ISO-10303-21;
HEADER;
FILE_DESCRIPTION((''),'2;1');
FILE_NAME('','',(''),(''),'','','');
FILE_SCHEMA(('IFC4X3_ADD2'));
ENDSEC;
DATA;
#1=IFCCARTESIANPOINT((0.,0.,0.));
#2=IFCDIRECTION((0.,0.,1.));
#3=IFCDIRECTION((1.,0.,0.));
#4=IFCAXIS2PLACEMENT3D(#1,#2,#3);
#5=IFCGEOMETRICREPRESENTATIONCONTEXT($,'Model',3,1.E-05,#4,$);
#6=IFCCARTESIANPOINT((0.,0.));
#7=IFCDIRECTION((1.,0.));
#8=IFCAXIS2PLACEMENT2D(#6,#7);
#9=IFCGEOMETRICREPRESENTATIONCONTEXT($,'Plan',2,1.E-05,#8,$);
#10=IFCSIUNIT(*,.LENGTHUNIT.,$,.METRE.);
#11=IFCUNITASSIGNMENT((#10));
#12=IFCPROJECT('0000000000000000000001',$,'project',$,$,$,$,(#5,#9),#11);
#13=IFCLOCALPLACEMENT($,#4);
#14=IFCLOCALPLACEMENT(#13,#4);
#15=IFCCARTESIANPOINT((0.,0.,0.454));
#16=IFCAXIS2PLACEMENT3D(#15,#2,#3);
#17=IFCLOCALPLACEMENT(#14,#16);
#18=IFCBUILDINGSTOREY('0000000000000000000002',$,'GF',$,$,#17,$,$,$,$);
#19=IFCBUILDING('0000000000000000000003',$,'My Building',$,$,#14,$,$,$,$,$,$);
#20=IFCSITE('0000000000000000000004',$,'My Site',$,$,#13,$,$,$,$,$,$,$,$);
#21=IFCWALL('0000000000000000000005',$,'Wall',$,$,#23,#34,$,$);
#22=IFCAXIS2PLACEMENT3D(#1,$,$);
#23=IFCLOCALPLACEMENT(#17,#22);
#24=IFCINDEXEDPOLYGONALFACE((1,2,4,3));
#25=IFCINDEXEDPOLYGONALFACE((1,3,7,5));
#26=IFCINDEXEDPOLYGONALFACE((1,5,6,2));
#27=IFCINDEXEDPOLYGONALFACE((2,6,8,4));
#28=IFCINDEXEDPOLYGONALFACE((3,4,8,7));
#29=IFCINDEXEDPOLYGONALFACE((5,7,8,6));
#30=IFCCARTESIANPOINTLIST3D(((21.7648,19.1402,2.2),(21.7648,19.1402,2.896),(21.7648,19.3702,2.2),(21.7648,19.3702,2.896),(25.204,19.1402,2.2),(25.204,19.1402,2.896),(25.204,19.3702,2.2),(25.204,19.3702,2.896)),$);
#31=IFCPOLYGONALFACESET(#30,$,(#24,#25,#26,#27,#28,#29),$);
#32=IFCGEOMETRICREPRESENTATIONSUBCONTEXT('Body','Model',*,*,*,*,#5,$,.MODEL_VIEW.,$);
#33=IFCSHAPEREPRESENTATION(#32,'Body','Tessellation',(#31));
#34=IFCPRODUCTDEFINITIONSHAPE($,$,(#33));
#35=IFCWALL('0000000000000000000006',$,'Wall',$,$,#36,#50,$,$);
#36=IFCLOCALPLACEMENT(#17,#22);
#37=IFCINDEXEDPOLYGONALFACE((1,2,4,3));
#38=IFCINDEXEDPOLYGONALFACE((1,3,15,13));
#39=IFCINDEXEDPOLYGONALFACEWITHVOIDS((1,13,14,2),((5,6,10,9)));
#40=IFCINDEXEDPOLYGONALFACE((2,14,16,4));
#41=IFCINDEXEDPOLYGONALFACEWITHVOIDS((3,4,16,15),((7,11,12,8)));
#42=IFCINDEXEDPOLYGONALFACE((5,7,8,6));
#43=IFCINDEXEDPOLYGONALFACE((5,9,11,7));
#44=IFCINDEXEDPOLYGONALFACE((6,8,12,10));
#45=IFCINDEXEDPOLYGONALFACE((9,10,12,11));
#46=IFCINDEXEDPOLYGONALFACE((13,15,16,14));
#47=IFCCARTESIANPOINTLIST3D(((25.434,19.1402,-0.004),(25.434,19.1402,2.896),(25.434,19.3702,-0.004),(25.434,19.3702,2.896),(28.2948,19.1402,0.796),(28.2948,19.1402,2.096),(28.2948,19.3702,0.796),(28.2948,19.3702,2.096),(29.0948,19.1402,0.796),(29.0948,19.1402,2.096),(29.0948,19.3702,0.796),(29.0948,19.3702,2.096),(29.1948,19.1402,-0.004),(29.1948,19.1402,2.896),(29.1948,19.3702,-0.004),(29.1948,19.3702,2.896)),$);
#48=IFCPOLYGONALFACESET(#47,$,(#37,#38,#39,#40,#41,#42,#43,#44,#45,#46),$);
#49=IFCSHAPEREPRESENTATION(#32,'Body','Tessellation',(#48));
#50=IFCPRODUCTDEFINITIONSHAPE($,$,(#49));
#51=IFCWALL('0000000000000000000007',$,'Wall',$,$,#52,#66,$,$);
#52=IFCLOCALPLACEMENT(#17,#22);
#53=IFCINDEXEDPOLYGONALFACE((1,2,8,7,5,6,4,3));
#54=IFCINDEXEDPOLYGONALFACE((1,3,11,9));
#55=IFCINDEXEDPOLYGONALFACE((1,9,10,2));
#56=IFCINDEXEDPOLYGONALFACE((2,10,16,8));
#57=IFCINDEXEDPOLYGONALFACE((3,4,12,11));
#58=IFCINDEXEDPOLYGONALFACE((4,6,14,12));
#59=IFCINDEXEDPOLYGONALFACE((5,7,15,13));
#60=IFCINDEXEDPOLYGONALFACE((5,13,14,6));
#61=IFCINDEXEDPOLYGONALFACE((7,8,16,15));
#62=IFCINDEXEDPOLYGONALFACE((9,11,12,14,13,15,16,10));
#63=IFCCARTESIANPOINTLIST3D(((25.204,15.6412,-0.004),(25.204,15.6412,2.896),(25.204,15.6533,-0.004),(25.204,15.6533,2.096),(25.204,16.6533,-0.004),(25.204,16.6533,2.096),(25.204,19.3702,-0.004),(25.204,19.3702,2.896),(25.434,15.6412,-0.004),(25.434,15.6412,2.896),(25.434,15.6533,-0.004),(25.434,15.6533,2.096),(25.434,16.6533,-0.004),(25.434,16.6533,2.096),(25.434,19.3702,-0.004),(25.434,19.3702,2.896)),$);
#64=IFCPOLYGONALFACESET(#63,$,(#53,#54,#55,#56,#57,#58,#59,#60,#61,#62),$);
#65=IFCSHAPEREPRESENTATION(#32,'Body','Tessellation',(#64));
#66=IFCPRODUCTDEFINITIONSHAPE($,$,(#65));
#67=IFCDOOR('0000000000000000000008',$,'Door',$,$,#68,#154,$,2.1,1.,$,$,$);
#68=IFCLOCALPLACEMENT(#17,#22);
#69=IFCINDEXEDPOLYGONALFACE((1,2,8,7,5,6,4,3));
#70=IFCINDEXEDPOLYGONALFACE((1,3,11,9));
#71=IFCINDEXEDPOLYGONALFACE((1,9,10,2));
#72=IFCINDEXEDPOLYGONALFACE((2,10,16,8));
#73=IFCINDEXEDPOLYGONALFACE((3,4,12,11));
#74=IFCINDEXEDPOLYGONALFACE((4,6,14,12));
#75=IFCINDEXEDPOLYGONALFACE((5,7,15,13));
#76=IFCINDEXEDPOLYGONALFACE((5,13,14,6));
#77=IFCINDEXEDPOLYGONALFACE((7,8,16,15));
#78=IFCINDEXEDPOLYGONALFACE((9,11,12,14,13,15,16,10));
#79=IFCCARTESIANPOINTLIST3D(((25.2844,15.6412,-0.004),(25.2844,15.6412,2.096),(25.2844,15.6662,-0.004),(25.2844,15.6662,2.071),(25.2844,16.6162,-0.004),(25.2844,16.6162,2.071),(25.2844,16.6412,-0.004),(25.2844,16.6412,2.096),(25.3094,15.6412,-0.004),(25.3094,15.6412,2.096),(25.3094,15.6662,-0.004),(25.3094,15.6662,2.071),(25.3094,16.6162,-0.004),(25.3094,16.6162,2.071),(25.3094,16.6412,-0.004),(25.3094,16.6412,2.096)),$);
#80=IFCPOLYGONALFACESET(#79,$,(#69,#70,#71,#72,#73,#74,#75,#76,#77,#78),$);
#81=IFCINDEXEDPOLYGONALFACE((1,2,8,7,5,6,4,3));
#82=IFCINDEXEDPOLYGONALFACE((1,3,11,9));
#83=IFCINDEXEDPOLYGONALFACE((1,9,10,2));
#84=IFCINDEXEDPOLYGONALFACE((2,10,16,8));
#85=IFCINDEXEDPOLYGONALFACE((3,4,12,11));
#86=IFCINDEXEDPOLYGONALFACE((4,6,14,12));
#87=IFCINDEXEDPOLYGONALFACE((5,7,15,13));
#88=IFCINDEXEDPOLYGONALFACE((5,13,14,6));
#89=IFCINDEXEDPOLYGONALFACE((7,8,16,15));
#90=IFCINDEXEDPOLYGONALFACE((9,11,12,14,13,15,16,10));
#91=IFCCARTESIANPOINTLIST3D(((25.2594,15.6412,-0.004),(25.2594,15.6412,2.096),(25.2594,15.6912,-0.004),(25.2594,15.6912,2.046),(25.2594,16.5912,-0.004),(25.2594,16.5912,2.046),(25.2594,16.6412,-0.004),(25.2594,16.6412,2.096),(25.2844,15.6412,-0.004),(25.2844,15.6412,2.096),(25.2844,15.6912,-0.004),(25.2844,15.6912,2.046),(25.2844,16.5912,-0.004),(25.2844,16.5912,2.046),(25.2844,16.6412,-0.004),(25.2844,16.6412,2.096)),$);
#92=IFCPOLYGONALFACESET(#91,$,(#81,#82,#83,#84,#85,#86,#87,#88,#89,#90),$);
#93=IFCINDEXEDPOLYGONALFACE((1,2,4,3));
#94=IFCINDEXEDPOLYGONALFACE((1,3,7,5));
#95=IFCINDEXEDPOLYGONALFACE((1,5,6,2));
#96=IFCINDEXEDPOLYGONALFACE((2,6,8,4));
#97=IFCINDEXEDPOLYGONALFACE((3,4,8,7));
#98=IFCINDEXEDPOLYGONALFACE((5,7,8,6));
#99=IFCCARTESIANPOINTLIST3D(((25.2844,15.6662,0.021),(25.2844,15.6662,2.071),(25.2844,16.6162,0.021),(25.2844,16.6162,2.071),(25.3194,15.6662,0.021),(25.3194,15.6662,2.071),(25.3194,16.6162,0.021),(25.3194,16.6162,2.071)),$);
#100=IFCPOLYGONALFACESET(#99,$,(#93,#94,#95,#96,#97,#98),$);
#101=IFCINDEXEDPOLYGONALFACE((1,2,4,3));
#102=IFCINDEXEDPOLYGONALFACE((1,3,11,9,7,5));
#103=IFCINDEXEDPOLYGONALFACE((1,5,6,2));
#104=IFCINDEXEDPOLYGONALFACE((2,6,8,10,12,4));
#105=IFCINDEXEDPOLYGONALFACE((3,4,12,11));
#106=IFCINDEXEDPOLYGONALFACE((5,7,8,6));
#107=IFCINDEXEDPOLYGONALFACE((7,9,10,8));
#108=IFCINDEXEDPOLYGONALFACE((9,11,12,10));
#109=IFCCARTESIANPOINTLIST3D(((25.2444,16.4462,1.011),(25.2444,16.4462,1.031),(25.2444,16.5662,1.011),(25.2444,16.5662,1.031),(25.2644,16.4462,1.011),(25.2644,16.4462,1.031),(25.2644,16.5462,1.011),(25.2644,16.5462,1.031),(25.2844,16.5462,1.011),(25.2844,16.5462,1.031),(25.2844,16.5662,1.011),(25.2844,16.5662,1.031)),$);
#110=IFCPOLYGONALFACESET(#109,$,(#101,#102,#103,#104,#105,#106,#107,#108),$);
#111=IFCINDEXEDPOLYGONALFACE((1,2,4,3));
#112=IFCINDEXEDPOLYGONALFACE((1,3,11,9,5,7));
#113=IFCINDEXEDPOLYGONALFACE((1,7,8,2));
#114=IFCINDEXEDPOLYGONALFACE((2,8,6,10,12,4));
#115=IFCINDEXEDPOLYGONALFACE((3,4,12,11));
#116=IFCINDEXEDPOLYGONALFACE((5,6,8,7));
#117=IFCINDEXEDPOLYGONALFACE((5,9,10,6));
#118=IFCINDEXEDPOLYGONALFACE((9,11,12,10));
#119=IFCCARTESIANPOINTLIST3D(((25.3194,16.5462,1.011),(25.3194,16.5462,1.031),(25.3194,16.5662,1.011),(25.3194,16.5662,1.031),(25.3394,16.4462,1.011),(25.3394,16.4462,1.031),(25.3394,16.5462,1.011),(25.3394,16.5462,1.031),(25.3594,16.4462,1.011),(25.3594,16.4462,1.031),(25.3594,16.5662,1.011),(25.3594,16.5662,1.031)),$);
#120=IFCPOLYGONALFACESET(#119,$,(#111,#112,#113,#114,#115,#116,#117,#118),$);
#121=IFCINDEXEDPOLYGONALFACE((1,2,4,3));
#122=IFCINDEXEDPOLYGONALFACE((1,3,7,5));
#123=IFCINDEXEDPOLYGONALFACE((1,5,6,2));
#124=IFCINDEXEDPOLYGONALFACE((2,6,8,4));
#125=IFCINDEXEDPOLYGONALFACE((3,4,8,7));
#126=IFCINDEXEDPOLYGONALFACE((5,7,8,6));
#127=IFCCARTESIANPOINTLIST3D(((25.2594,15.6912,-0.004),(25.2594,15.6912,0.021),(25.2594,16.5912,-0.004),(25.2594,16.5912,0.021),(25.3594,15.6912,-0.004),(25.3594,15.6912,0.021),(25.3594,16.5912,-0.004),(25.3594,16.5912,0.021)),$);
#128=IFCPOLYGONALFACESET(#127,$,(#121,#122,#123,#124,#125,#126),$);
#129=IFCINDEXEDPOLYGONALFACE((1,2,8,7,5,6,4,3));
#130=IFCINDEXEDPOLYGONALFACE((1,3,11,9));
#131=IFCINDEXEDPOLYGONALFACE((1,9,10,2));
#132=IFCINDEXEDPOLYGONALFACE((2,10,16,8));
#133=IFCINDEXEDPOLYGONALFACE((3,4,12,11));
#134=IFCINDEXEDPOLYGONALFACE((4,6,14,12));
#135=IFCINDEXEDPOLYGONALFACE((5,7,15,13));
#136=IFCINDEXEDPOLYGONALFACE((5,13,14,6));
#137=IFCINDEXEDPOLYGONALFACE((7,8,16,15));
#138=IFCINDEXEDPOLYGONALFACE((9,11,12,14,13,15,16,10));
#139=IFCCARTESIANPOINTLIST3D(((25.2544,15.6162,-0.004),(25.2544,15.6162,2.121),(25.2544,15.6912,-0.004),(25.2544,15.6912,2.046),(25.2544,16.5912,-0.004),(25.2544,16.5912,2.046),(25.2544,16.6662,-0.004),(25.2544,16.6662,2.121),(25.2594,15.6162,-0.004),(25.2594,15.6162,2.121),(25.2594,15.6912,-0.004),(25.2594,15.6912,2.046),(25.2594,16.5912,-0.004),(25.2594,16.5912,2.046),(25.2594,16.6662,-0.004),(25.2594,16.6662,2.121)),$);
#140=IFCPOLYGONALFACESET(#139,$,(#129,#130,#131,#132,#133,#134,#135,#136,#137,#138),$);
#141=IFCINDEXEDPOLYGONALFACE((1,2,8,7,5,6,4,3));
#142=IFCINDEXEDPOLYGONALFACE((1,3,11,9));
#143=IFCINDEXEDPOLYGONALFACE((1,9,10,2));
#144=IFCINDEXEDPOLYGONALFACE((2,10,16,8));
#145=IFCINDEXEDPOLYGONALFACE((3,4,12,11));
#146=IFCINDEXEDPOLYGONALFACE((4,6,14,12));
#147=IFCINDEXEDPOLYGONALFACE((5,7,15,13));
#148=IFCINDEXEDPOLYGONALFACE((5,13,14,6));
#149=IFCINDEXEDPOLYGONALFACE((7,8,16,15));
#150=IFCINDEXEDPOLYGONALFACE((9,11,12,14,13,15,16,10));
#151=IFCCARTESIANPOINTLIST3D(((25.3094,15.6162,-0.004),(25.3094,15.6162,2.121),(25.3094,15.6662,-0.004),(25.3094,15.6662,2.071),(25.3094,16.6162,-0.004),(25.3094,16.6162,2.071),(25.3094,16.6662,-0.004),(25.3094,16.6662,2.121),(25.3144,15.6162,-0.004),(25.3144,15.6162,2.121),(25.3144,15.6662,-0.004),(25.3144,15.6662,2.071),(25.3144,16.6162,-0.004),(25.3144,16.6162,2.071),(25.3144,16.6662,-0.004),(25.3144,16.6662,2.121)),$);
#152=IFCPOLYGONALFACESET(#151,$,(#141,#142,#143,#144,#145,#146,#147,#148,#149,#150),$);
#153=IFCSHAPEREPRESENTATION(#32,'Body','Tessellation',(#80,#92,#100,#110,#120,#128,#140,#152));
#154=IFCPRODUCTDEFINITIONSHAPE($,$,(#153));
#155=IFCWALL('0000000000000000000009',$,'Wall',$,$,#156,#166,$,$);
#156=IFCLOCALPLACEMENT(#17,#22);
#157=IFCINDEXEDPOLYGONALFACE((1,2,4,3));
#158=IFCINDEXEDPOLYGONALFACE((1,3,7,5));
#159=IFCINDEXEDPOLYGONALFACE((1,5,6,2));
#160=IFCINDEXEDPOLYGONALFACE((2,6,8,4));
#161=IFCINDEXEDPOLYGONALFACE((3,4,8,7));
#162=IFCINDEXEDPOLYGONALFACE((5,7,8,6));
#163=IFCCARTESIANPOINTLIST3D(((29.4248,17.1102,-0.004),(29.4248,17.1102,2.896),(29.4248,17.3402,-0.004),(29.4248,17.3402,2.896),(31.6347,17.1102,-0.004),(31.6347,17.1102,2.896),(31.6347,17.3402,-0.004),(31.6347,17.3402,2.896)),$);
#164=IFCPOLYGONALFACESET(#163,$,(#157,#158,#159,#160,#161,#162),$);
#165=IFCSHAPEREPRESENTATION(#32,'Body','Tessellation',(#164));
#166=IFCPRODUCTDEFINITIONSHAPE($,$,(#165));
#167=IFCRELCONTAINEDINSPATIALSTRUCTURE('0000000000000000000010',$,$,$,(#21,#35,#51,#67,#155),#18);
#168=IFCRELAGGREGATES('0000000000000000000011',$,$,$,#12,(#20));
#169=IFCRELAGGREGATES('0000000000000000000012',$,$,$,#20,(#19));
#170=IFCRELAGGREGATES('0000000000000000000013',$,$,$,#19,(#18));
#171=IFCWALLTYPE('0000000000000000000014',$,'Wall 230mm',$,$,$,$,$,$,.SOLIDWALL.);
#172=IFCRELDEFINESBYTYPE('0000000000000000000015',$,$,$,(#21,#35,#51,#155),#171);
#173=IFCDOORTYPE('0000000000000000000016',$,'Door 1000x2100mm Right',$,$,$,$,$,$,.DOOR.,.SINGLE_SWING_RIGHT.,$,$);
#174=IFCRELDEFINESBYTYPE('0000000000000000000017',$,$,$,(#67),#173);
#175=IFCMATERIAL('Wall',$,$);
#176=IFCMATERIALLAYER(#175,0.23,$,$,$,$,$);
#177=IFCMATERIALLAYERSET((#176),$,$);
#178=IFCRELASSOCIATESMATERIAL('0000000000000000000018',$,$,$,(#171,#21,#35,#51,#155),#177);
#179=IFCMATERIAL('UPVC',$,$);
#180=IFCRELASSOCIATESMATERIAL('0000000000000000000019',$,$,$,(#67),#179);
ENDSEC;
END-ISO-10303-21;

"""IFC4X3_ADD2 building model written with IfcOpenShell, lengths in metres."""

from ifc_helpers import new_model, entity, si_unit, frame, origin_with_axes, origin_2d_with_axis, place, context, subcontext, project, spatial, line, indexed_curve, outline, extrude, clip, halfspace, shape, source, transform, mapped, material, layer, layer_set, layer_usage, type_object, type_shapes, element, fill, save


model = new_model("IFC4X3_ADD2")

# Units and contexts
model_context = context("Model", 3, precision=1e-05, world=origin_with_axes())
plan_context = context("Plan", 2, precision=1e-05, world=origin_2d_with_axis())
body_context_1 = subcontext(model_context, "Body", "Model", "MODEL_VIEW")
body_context_2 = subcontext(plan_context, "Body", "Plan", "PLAN_VIEW")
ifc_project = project(units=[si_unit("LENGTHUNIT", "METRE")], contexts=[model_context, plan_context])

# Site, building, storey
site_placement = place(None, origin_with_axes())
site = spatial("IfcSite", under=ifc_project, at=site_placement, Name="My Site")
building_placement = place(site_placement, origin_with_axes())
building = spatial("IfcBuilding", under=site, at=building_placement, Name="My Building")
storey_placement = place(building_placement, frame((0.0, 0.0, 0.454), z_axis=(0.0, 0.0, 1.0), x_axis=(1.0, 0.0, 0.0)))
storey = spatial("IfcBuildingStorey", under=building, at=storey_placement, Name="GF")

# Shared definitions
ifc_material_1 = material(Name="Wall")
ifc_layer = layer(ifc_material_1, 0.23)
ifc_layer_set = layer_set([ifc_layer])
wall_type = type_object("IfcWallType", Name="Wall 230mm", PredefinedType="SOLIDWALL", material=ifc_layer_set)
shared_shape_1 = source(origin_with_axes(), body_context_1, "Body", "SweptSolid", [
    extrude(outline(indexed_curve([(0.0, 0.0), (0.8, 0.0), (0.8, 1.3), (0.0, 1.3)], segments=[line(1, 2, 3, 4, 1)])), frame((-0.4, -0.6, 0.0), z_axis=(0.0, -1.0, 0.0), x_axis=(1.0, 0.0, 0.0)), (0.0, 0.0, -1.0), 1.2),
])

# Wall
ifc_layer_usage_1 = layer_usage(ifc_layer_set, "AXIS2", "POSITIVE", 0.0)
wall_1_placement = place(storey_placement, frame((25.204, 19.3702, 2.2), z_axis=(0.0, 0.0, 1.0), x_axis=(-1.0, 0.0, 0.0)))
element("IfcWall", 1, at=wall_1_placement, inside=storey, type_object=wall_type, material=ifc_layer_usage_1, Name="Wall", context=body_context_1, shape_type="Clipping", body=[
    clip(clip(extrude(outline(indexed_curve([(0.0, 0.0), (0.0, 0.23), (3.4392, 0.23), (3.4392, 0.0), (0.0, 0.0)], self_intersect=False)), origin_with_axes(), (0.0, 0.0, 1.0), 6.25), halfspace(frame((0.0, 0.0, 3.596), z_axis=(0.0, 0.0, 1.0), x_axis=(-1.0, 0.0, 0.0)), False)), halfspace(frame((0.0, 0.0, 0.696), z_axis=(0.0, 0.0, 1.0), x_axis=(-1.0, 0.0, 0.0)), False)),
])

# Wall, opening
ifc_layer_usage_2 = layer_usage(ifc_layer_set, "AXIS2", "POSITIVE", 0.0)
wall_2_placement = place(storey_placement, frame((29.1948, 19.3702, -0.004), z_axis=(0.0, 0.0, 1.0), x_axis=(-1.0, 0.0, 0.0)))
wall_2 = element("IfcWall", 2, at=wall_2_placement, inside=storey, type_object=wall_type, material=ifc_layer_usage_2, Name="Wall", context=body_context_1, shape_type="SweptSolid", body=[
    extrude(outline(indexed_curve([(0.0, 0.0), (0.0, 0.23), (3.7608, 0.23), (3.7608, 0.0), (0.0, 0.0)], self_intersect=False)), origin_with_axes(), (0.0, 0.0, 1.0), 2.9),
])
opening_1_placement = place(wall_2_placement, frame((0.5, 0.16, 0.8), z_axis=(0.0, 0.0, 1.0), x_axis=(1.0, 0.0, 0.0)))
element("IfcOpeningElement", 3, at=opening_1_placement, cuts=wall_2, PredefinedType="OPENING", context=body_context_1, shape_type="MappedRepresentation", body=[
    mapped(shared_shape_1, transform((0.0, 0.0, 0.0), x_axis=(1.0, 0.0, 0.0), y_axis=(0.0, 1.0, 0.0), z_axis=(0.0, 0.0, 1.0), scale=1.0)),
])

# Wall, opening, door
ifc_layer_usage_3 = layer_usage(ifc_layer_set, "AXIS2", "POSITIVE", 0.0)
wall_3_placement = place(storey_placement, frame((25.434, 15.6412, -0.004), z_axis=(0.0, 0.0, 1.0), x_axis=(0.000001, 1.0, 0.0)))
wall_3 = element("IfcWall", 4, at=wall_3_placement, inside=storey, type_object=wall_type, material=ifc_layer_usage_3, Name="Wall", context=body_context_1, shape_type="SweptSolid", body=[
    extrude(outline(indexed_curve([(0.0, 0.0), (0.0, 0.23), (3.729, 0.23), (3.729, 0.0), (0.0, 0.0)], self_intersect=False)), origin_with_axes(), (0.0, 0.0, 1.0), 2.9),
])
shared_shape_2 = source(origin_with_axes(), body_context_1, "Body", "SweptSolid", [
    extrude(outline(indexed_curve([(0.0, 0.0), (1.0, 0.0), (1.0, 2.1), (0.0, 2.1)], segments=[line(1, 2, 3, 4, 1)])), frame((0.0, -0.6, 0.0), z_axis=(0.0, -1.0, 0.0), x_axis=(1.0, 0.0, 0.0)), (0.0, 0.0, -1.0), 1.2),
])
opening_2_placement = place(wall_3_placement, frame((0.012, 0.0, 0.0), z_axis=(0.0, 0.0, 1.0), x_axis=(1.0, 0.0, 0.0)))
opening_2 = element("IfcOpeningElement", 5, at=opening_2_placement, cuts=wall_3, PredefinedType="OPENING", context=body_context_1, shape_type="MappedRepresentation", body=[
    mapped(shared_shape_2, transform((0.0, 0.0, 0.0), x_axis=(1.0, 0.0, 0.0), y_axis=(0.0, 1.0, 0.0), z_axis=(0.0, 0.0, 1.0), scale=1.0)),
])
ifc_material_2 = material(Name="UPVC")
door_type_1 = type_object("IfcDoorType", Name="Door 1000x2100mm Right", OperationType="SINGLE_SWING_RIGHT", PredefinedType="DOOR")
shared_shape_3 = source(origin_with_axes(), body_context_1, "Body", "SweptSolid", [
    extrude(outline(indexed_curve([(0.0, 0.0), (0.0, 2.1), (1.0, 2.1), (1.0, 0.0), (0.975, 0.0), (0.975, 2.075), (0.025, 2.075), (0.025, 0.0)], segments=[line(1, 2, 3, 4, 5, 6, 7, 8, 1)])), frame((0.0, 0.025, 0.0), z_axis=(0.0, -1.0, 0.0), x_axis=(1.0, 0.0, 0.0)), (0.0, 0.0, -1.0), 0.025),
    extrude(outline(indexed_curve([(0.0, 0.0), (0.0, 2.1), (1.0, 2.1), (1.0, 0.0), (0.95, 0.0), (0.95, 2.05), (0.05, 2.05), (0.05, 0.0)], segments=[line(1, 2, 3, 4, 5, 6, 7, 8, 1)])), frame((0.0, 0.0, 0.0), z_axis=(0.0, -1.0, 0.0), x_axis=(1.0, 0.0, 0.0)), (0.0, 0.0, -1.0), 0.025),
    extrude(outline(indexed_curve([(0.0, 0.0), (0.95, 0.0), (0.95, 0.035), (0.0, 0.035)], segments=[line(1, 2, 3, 4, 1)])), frame((0.025, 0.025, 0.025), z_axis=(0.0, 0.0, 1.0), x_axis=(1.0, 0.0, 0.0)), (0.0, 0.0, 1.0), 2.05),
    extrude(outline(indexed_curve([(0.0, 0.0), (0.0, -0.04), (0.12, -0.04), (0.12, -0.02), (0.02, -0.02), (0.02, 0.0)], segments=[line(1, 2, 3, 4, 5, 6, 1)])), frame((0.075, 0.025, 1.015), z_axis=(0.0, 0.0, 1.0), x_axis=(1.0, 0.0, 0.0)), (0.0, 0.0, 1.0), 0.02),
    extrude(outline(indexed_curve([(0.0, 0.0), (0.0, 0.04), (0.12, 0.04), (0.12, 0.02), (0.02, 0.02), (0.02, 0.0)], segments=[line(1, 2, 3, 4, 5, 6, 1)])), frame((0.075, 0.06, 1.015), z_axis=(0.0, 0.0, 1.0), x_axis=(1.0, 0.0, 0.0)), (0.0, 0.0, 1.0), 0.02),
    extrude(outline(indexed_curve([(0.0, 0.0), (0.9, 0.0), (0.9, 0.1), (0.0, 0.1)], segments=[line(1, 2, 3, 4, 1)])), frame((0.05, 0.0, 0.0), z_axis=(0.0, 0.0, 1.0), x_axis=(1.0, 0.0, 0.0)), (0.0, 0.0, 1.0), 0.025),
    extrude(outline(indexed_curve([(0.0, 0.0), (0.0, 2.125), (1.05, 2.125), (1.05, 0.0), (0.975, 0.0), (0.975, 2.05), (0.075, 2.05), (0.075, 0.0)], segments=[line(1, 2, 3, 4, 5, 6, 7, 8, 1)])), frame((-0.025, -0.005, 0.0), z_axis=(0.0, -1.0, 0.0), x_axis=(1.0, 0.0, 0.0)), (0.0, 0.0, -1.0), 0.005),
    extrude(outline(indexed_curve([(0.0, 0.0), (0.0, 2.125), (1.05, 2.125), (1.05, 0.0), (1.0, 0.0), (1.0, 2.075), (0.05, 2.075), (0.05, 0.0)], segments=[line(1, 2, 3, 4, 5, 6, 7, 8, 1)])), frame((-0.025, 0.05, 0.0), z_axis=(0.0, -1.0, 0.0), x_axis=(1.0, 0.0, 0.0)), (0.0, 0.0, -1.0), 0.005),
])
shared_shape_4 = source(origin_with_axes(), body_context_2, "Body", "Curve2D", [
    entity("IfcIndexedPolyCurve", entity("IfcCartesianPointList2D", [[0.0, 0.0], [0.0, 0.05], [0.025, 0.05], [0.025, 0.025], [0.05, 0.025], [0.05, 0.0]]), [entity("IfcLineIndex", [1, 2, 3, 4, 5, 6, 1])]),
    entity("IfcIndexedPolyCurve", entity("IfcCartesianPointList2D", [[1.0, 0.0], [1.0, 0.05], [0.975, 0.05], [0.975, 0.025], [0.95, 0.025], [0.95, 0.0]]), [entity("IfcLineIndex", [1, 2, 3, 4, 5, 6, 1])]),
    entity("IfcTrimmedCurve", entity("IfcEllipse", entity("IfcAxis2Placement2D", entity("IfcCartesianPoint", [0.94, 0.05]), entity("IfcDirection", [1.0, 0.0])), 0.915, 0.95), [entity("IfcCartesianPoint", [0.94, 1.0])], [entity("IfcCartesianPoint", [0.025, 0.05])], True, "CARTESIAN"),
    entity("IfcIndexedPolyCurve", entity("IfcCartesianPointList2D", [[0.975, 0.05], [0.94, 0.05], [0.94, 1.0], [0.975, 1.0]]), [entity("IfcLineIndex", [1, 2, 3, 4, 1])]),
])
type_shapes(door_type_1, [shared_shape_3, shared_shape_4])
door_1_placement = place(opening_2_placement, frame((0.988, 0.1746, 0.0), z_axis=(0.0, 0.0, 1.0), x_axis=(-1.0, 0.0, 0.0)))
door_1 = element("IfcDoor", 6, at=door_1_placement, inside=storey, type_object=door_type_1, material=ifc_material_2, Name="Door", OverallHeight=2.1, OverallWidth=1.0, shapes=[
    shape(body_context_1, "Body", "MappedRepresentation", [mapped(shared_shape_3, transform((0.0, 0.0, 0.0), x_axis=(1.0, 0.0, 0.0), y_axis=(0.0, 1.0, 0.0), z_axis=(0.0, 0.0, 1.0), scale=1.0))]),
    shape(body_context_2, "Body", "MappedRepresentation", [mapped(shared_shape_4, transform((0.0, 0.0, 0.0), x_axis=(1.0, 0.0, 0.0), y_axis=(0.0, 1.0, 0.0), z_axis=(0.0, 0.0, 1.0), scale=1.0))]),
])
fill(opening_2, door_1)

# Wall
ifc_layer_usage_4 = layer_usage(ifc_layer_set, "AXIS2", "POSITIVE", 0.0)
wall_4_placement = place(storey_placement, frame((31.6347, 17.3402, -0.004), z_axis=(0.0, 0.0, 1.0), x_axis=(-1.0, 0.0, 0.0)))
element("IfcWall", 7, at=wall_4_placement, inside=storey, type_object=wall_type, material=ifc_layer_usage_4, Name="Wall", context=body_context_1, shape_type="SweptSolid", body=[
    extrude(outline(indexed_curve([(0.0, 0.0), (0.0, 0.23), (2.21, 0.23), (2.21, 0.0), (0.0, 0.0)], self_intersect=False)), origin_with_axes(), (0.0, 0.0, 1.0), 2.9),
])

save(model, "model.ifc")
